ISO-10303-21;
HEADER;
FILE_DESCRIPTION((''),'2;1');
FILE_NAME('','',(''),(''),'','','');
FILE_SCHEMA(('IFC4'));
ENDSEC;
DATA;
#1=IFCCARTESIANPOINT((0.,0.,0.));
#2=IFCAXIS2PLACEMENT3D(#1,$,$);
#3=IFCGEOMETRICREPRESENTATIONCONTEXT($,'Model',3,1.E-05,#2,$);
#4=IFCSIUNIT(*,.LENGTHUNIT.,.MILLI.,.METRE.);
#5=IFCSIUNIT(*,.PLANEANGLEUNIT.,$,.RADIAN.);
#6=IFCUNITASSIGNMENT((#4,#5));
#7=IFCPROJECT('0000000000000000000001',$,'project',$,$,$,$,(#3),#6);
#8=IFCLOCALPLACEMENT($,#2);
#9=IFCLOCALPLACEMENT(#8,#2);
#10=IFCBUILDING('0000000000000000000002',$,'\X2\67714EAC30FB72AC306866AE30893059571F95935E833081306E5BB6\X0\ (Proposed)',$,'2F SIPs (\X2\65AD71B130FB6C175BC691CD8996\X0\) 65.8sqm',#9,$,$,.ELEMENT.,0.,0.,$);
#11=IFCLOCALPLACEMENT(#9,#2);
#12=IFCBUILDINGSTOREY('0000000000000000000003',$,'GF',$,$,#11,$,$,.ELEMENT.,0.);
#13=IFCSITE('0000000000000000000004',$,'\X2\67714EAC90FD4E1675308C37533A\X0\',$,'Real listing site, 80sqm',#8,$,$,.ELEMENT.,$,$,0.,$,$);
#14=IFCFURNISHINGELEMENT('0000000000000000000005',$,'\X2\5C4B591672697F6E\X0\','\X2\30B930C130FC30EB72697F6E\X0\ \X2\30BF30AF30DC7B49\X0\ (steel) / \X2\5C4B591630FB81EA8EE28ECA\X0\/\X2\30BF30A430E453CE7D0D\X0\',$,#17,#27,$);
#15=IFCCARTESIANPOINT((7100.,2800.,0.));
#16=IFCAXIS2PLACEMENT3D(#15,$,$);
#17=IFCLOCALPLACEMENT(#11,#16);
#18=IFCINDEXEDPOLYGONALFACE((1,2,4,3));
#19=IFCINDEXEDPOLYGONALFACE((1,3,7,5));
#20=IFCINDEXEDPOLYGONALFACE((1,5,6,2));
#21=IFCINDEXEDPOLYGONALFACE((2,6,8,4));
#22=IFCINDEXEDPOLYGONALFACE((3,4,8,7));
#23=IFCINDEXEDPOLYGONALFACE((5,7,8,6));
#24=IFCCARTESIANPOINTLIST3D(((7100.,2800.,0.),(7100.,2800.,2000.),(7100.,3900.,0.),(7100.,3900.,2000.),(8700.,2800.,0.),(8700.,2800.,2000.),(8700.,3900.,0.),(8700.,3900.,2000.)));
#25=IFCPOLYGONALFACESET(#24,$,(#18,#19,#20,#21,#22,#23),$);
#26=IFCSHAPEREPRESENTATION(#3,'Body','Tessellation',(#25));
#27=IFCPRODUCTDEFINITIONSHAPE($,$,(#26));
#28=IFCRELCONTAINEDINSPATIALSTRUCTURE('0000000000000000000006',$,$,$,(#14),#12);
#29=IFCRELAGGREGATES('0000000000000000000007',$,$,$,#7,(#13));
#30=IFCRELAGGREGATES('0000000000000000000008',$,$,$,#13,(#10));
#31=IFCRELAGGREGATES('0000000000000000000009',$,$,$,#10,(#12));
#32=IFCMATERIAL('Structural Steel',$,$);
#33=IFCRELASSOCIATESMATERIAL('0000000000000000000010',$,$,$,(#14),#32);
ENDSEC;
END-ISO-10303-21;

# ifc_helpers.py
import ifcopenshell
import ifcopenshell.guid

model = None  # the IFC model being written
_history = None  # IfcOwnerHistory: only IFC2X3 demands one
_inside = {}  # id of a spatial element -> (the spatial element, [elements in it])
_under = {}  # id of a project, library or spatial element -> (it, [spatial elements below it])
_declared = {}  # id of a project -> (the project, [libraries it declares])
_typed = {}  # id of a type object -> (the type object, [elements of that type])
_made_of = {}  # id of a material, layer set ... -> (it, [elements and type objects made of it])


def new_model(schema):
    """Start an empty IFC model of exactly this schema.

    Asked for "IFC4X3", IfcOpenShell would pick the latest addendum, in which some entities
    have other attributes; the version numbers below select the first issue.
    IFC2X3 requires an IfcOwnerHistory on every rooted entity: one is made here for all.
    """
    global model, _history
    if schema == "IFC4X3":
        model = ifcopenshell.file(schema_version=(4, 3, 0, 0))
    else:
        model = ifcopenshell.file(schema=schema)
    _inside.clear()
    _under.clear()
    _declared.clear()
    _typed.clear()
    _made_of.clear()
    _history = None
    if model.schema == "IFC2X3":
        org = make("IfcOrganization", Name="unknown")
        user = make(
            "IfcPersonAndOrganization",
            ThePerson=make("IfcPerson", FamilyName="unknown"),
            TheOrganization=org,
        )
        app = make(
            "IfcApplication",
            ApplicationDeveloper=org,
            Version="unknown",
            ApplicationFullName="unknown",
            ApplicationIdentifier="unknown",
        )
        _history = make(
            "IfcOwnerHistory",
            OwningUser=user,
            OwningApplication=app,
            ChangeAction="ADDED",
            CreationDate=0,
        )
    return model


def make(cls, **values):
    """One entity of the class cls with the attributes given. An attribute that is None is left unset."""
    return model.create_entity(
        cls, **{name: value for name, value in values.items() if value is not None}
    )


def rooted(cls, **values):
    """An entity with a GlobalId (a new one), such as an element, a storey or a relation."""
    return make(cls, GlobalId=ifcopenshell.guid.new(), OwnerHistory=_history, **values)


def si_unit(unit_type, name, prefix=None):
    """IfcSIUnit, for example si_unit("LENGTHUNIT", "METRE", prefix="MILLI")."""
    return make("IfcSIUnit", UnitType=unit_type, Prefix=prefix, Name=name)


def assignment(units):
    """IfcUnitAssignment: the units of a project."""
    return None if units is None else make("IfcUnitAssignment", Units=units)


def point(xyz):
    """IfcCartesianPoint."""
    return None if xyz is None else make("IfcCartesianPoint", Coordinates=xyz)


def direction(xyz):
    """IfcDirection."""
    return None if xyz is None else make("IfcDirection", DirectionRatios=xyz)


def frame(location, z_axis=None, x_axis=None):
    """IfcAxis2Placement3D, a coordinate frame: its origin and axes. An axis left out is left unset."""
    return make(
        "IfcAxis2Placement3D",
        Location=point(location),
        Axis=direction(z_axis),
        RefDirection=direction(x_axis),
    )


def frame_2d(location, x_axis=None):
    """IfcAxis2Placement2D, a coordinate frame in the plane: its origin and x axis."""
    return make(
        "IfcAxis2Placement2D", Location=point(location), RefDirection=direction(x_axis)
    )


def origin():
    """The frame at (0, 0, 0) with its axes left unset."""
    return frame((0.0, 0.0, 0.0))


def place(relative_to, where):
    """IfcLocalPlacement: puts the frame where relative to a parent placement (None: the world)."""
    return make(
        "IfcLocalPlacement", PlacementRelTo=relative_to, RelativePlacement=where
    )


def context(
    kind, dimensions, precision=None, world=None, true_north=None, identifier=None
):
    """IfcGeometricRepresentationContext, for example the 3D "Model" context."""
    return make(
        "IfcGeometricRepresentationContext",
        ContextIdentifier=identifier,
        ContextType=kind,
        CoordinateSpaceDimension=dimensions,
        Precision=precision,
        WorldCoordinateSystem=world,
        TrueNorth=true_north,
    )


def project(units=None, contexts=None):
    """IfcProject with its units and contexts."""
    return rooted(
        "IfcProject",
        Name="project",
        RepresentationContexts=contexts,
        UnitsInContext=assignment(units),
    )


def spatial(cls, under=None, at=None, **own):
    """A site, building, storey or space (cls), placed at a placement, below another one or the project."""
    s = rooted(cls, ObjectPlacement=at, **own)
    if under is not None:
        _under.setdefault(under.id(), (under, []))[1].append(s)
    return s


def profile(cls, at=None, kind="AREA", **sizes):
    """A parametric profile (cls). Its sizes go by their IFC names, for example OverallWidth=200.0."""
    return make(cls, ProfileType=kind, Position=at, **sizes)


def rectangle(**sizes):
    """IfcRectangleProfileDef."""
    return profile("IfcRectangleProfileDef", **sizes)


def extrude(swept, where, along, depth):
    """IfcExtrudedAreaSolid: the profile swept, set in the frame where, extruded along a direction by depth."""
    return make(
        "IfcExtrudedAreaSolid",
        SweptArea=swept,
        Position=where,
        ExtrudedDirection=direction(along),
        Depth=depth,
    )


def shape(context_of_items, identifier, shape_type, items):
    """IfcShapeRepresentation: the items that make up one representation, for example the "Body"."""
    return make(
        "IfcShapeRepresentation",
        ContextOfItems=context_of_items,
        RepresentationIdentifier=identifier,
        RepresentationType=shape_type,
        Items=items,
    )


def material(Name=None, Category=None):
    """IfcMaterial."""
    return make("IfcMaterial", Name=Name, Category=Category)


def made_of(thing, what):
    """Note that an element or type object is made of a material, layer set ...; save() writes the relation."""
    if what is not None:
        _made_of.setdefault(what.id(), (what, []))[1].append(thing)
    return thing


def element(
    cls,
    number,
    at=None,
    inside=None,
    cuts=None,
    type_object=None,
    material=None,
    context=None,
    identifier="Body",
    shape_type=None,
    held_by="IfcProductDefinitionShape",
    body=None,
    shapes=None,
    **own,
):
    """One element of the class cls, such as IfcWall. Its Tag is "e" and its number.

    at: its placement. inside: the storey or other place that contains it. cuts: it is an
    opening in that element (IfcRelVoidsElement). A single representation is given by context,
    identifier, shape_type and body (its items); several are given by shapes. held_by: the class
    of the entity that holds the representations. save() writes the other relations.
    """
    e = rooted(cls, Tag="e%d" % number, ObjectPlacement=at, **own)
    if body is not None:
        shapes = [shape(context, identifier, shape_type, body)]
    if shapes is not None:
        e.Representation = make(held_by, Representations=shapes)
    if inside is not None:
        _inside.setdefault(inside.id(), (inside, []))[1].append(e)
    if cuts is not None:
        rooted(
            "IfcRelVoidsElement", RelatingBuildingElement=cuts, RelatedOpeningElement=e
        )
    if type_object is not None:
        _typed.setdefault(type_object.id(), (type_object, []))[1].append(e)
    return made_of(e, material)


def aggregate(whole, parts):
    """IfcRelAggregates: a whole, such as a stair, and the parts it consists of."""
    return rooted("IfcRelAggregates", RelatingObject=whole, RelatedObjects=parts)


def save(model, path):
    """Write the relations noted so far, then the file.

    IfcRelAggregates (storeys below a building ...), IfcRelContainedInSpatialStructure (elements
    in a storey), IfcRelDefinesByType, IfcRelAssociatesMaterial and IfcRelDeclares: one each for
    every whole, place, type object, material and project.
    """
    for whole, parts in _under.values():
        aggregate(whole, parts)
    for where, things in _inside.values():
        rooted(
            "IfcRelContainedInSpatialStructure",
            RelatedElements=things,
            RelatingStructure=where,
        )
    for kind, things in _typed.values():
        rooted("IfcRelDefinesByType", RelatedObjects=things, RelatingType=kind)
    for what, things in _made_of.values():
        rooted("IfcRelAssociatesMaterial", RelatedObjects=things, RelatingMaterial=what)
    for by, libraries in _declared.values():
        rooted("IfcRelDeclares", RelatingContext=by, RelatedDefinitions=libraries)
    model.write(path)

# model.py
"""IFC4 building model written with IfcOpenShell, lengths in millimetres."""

from ifc_helpers import new_model, si_unit, frame, frame_2d, origin, place, context, project, spatial, rectangle, extrude, material, element, save


model = new_model("IFC4")

# Units and contexts
model_context = context("Model", 3, precision=1e-05, world=origin())
ifc_project = project(units=[si_unit("LENGTHUNIT", "METRE", prefix="MILLI"), si_unit("PLANEANGLEUNIT", "RADIAN")], contexts=[model_context])

# Site, building, storey
site_placement = place(None, origin())
site = spatial("IfcSite", under=ifc_project, at=site_placement, Name="東京都世田谷区", ObjectType="Real listing site, 80sqm", CompositionType="ELEMENT", RefElevation=0.0)
building_placement = place(site_placement, origin())
building = spatial("IfcBuilding", under=site, at=building_placement, Name="東京・犬と暮らす土間広めの家 (Proposed)", ObjectType="2F SIPs (断熱・気密重視) 65.8sqm", CompositionType="ELEMENT", ElevationOfRefHeight=0.0, ElevationOfTerrain=0.0)
storey_placement = place(building_placement, origin())
storey = spatial("IfcBuildingStorey", under=building, at=storey_placement, Name="GF", CompositionType="ELEMENT", Elevation=0.0)

# Shared definitions
ifc_material_1 = material(Name="Structural Steel")

# Furnishing element
furnishing_1_placement = place(storey_placement, frame((7100.0, 2800.0, 0.0)))
element("IfcFurnishingElement", 1, at=furnishing_1_placement, inside=storey, material=ifc_material_1, Name="屋外物置", Description="スチール物置 タクボ等 (steel) / 屋外・自転車/タイヤ収納", context=model_context, shape_type="SweptSolid", body=[
    extrude(rectangle(XDim=1600.0, YDim=1100.0, at=frame_2d((800.0, 550.0))), frame((7100.0, 2800.0, 0.0)), (0.0, 0.0, 1.0), 2000.0),
])

save(model, "model.ifc")
